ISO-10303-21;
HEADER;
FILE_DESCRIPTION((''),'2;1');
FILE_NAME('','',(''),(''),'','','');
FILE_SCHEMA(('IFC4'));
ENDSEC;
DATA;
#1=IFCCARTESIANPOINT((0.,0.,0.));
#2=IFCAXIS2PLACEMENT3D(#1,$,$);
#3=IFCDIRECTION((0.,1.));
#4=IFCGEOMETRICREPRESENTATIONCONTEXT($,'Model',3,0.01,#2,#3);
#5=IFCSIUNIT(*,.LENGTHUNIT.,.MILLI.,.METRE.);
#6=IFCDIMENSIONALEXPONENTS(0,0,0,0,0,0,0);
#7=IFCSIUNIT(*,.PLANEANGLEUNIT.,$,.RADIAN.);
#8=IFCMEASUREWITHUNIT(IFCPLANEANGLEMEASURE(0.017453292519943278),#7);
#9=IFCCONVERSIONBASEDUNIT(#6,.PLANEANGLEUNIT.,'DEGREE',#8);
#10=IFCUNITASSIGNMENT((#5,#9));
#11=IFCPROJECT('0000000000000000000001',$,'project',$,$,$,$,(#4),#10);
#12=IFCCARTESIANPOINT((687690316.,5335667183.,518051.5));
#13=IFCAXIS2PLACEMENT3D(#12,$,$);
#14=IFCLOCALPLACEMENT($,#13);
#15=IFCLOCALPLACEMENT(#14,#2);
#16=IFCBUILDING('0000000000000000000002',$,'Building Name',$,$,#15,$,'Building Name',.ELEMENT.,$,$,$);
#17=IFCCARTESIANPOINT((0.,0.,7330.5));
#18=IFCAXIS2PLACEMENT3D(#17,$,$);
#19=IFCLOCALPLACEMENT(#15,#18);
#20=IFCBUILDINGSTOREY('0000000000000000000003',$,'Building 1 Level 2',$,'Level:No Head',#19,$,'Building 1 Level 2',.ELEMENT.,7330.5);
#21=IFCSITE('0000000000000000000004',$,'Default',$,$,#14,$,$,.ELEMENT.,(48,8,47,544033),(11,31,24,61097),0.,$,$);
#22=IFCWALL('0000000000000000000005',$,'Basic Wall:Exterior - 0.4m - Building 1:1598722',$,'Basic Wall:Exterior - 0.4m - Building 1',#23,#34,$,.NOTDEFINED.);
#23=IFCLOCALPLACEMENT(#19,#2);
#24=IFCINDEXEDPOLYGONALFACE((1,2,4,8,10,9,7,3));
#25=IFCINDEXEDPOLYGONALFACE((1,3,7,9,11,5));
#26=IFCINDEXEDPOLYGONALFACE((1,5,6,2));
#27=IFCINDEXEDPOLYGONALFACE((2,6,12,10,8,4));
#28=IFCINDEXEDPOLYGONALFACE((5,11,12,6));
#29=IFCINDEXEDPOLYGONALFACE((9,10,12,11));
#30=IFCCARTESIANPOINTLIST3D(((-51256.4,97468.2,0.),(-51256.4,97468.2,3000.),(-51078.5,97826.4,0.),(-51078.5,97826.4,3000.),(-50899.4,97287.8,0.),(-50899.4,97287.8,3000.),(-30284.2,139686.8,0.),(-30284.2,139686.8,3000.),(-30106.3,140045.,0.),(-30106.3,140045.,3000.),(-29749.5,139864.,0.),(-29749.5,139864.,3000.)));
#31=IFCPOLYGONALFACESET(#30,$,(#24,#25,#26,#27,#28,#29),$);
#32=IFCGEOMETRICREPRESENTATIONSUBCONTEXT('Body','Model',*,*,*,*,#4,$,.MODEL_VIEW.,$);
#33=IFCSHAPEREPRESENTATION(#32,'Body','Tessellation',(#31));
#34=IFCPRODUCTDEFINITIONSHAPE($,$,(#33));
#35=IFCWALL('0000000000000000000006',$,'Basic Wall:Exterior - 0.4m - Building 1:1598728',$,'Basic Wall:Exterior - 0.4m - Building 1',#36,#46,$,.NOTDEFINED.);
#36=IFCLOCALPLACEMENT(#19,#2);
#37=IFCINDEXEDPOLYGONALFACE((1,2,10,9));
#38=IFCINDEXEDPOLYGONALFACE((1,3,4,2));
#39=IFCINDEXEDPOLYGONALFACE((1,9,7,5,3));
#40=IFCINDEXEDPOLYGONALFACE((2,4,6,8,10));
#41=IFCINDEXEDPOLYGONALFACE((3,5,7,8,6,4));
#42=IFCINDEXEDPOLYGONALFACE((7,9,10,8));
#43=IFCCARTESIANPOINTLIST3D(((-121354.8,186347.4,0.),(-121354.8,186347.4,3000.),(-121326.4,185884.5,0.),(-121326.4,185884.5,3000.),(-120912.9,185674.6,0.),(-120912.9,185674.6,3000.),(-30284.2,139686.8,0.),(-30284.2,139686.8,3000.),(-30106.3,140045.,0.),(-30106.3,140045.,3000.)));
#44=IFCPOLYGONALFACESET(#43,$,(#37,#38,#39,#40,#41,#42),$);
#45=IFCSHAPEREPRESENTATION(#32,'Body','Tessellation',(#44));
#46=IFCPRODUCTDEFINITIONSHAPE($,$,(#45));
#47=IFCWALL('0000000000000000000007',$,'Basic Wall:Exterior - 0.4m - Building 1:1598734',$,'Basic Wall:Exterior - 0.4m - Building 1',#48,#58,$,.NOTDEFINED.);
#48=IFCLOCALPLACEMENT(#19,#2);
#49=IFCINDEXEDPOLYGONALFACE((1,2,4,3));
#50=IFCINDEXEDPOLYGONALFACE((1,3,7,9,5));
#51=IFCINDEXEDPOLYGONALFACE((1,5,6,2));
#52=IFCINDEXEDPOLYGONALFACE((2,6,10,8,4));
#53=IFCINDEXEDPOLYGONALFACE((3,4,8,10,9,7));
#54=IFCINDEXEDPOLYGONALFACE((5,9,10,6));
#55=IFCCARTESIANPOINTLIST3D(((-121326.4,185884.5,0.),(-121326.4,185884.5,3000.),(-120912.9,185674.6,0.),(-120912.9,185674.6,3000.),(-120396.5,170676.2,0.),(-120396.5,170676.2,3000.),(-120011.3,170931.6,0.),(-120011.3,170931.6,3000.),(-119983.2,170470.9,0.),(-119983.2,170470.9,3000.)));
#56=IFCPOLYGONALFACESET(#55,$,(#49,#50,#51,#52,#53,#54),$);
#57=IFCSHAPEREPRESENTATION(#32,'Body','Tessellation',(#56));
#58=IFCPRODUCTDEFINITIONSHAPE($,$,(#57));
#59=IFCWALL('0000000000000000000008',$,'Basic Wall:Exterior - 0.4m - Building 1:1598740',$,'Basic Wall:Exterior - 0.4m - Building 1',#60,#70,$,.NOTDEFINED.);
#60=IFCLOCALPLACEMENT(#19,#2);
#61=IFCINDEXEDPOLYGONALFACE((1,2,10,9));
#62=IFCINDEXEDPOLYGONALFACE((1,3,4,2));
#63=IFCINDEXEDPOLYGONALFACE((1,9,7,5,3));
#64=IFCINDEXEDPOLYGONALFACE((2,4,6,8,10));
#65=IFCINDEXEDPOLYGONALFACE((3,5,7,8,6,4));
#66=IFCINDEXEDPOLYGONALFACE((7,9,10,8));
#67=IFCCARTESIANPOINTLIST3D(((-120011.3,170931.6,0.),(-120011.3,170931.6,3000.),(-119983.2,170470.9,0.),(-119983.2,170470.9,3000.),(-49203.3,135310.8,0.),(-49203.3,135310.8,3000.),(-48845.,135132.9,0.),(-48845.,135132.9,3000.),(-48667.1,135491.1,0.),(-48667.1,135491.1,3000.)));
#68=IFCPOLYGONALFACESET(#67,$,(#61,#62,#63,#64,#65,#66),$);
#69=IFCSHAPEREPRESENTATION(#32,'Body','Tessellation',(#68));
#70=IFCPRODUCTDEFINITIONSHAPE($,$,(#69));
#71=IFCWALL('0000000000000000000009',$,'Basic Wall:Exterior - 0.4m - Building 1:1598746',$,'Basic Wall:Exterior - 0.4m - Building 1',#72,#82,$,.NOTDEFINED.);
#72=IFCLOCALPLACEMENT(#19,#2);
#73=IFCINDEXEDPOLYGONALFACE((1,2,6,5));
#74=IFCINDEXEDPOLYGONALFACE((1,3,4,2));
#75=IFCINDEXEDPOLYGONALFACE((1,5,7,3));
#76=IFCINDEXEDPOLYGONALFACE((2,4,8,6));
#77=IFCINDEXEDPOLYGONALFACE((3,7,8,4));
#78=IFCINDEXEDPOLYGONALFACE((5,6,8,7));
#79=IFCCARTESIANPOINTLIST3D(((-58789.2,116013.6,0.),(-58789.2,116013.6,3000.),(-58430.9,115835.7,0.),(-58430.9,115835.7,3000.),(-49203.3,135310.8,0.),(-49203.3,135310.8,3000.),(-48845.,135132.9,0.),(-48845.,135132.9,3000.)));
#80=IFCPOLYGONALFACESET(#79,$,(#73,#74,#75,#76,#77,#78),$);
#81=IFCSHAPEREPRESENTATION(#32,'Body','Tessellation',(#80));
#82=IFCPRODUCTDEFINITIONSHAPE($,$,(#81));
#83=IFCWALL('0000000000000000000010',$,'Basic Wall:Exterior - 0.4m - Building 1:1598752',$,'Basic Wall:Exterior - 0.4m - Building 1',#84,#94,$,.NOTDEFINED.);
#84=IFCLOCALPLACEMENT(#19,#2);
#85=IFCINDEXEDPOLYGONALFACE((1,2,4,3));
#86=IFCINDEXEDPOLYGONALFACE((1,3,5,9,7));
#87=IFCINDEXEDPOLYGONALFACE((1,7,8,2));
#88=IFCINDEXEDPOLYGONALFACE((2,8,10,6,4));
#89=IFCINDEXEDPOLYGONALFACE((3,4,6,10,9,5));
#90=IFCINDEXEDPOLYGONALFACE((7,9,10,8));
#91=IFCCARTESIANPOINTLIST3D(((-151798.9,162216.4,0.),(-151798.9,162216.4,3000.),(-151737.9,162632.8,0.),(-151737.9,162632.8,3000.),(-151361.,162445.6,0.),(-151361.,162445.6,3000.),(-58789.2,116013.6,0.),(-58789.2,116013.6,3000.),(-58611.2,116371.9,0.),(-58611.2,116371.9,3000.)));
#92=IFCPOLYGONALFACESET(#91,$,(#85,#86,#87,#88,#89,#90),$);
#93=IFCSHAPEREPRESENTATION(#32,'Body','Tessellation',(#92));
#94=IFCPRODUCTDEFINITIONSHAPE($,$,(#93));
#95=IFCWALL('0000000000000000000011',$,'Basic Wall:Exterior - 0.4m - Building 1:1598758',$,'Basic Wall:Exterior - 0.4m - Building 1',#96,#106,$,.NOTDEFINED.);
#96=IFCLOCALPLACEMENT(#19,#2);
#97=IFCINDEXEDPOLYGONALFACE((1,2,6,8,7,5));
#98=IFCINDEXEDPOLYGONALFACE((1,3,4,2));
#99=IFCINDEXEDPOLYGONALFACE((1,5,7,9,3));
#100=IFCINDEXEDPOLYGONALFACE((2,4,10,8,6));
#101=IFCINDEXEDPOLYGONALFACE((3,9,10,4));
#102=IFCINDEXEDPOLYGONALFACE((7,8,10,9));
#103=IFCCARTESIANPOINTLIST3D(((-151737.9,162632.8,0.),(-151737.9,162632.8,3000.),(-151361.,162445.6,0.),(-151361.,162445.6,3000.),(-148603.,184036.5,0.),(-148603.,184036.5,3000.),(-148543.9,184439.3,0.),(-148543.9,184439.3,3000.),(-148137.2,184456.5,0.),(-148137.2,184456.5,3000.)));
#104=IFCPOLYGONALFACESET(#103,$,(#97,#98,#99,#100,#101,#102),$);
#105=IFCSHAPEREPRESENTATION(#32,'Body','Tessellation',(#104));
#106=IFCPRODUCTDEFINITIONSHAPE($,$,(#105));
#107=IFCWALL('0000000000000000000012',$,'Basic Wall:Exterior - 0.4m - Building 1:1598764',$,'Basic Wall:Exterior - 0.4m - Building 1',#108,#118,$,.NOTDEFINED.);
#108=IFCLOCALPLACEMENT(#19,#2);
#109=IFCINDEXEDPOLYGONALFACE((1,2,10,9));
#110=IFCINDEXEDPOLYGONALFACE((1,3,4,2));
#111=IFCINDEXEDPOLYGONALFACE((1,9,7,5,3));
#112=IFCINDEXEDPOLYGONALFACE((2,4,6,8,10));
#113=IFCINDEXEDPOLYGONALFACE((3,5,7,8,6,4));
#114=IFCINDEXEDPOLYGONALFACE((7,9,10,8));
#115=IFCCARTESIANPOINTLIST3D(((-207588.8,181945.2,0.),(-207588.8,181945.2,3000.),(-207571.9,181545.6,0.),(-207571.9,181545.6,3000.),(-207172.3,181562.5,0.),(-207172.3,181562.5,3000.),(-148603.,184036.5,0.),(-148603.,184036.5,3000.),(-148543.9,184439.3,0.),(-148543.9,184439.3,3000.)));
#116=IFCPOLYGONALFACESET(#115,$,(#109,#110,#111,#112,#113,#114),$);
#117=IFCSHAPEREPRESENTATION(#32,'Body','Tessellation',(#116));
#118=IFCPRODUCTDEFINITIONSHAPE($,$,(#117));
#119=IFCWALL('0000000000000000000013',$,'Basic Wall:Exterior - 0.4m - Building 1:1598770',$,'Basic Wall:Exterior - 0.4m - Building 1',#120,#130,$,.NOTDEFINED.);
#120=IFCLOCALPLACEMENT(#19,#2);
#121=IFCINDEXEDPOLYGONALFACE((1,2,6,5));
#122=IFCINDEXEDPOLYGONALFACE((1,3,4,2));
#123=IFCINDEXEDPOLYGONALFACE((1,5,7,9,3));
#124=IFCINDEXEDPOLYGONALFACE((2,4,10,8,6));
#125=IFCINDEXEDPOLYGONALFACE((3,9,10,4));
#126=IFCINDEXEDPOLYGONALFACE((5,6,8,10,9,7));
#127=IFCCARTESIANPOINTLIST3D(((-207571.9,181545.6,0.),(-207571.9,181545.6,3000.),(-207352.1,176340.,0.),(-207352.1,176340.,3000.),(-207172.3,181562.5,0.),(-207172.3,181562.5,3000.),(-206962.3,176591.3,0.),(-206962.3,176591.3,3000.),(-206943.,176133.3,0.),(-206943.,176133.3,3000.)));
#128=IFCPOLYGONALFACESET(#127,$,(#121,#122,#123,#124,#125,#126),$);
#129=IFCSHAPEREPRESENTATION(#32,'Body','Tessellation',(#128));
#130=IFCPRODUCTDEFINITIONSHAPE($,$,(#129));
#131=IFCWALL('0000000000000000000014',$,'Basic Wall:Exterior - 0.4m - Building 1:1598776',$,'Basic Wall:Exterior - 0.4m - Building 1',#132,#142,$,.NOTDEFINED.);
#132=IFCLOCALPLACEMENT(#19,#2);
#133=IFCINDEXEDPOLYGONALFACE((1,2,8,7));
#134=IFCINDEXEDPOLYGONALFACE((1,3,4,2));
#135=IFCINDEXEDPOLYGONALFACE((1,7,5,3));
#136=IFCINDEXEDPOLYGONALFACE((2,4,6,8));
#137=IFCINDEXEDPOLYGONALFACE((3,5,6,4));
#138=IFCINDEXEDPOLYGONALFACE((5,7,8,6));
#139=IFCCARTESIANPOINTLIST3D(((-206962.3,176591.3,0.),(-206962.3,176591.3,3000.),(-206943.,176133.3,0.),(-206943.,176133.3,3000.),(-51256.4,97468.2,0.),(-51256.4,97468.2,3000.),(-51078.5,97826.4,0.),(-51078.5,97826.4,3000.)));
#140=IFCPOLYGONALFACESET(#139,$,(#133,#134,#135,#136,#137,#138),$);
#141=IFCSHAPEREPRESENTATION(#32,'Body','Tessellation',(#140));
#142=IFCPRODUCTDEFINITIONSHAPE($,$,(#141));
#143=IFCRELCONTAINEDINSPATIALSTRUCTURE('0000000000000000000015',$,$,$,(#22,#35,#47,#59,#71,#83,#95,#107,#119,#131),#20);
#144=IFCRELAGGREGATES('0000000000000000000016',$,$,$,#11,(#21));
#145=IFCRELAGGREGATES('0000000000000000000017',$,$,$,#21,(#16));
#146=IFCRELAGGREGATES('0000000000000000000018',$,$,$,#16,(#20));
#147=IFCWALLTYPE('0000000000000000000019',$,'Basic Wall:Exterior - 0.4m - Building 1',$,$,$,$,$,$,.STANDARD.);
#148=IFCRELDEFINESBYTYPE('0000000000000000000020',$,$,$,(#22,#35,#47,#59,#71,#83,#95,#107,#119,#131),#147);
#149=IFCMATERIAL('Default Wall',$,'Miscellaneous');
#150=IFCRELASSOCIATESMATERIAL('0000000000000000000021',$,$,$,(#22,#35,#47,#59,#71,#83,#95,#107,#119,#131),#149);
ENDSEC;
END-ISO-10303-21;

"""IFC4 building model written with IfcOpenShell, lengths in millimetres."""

from ifc_helpers import new_model, entity, si_unit, converted_unit, direction, frame, origin, place, context, subcontext, project, spatial, indexed_curve, outline, extrude, material, type_object, element, save


model = new_model("IFC4")

# Units and contexts
model_context = context("Model", 3, precision=0.01, world=origin(), true_north=direction((0.0, 1.0)))
body_context = subcontext(model_context, "Body", "Model", "MODEL_VIEW")
ifc_project = project(units=[si_unit("LENGTHUNIT", "METRE", prefix="MILLI"), converted_unit("PLANEANGLEUNIT", "DEGREE", entity("IfcPlaneAngleMeasure", 0.017453292519943278), si_unit("PLANEANGLEUNIT", "RADIAN"), dimensions=[0, 0, 0, 0, 0, 0, 0])], contexts=[model_context])

# Site, building, storey
site_placement = place(None, frame((687690316.0, 5335667183.0, 518051.5)))
site = spatial("IfcSite", under=ifc_project, at=site_placement, Name="Default", CompositionType="ELEMENT", RefLatitude=(48, 8, 47, 544033), RefLongitude=(11, 31, 24, 61097), RefElevation=0.0)
building_placement = place(site_placement, origin())
building = spatial("IfcBuilding", under=site, at=building_placement, Name="Building Name", LongName="Building Name", CompositionType="ELEMENT")
storey_placement = place(building_placement, frame((0.0, 0.0, 7330.5)))
storey = spatial("IfcBuildingStorey", under=building, at=storey_placement, Name="Building 1 Level 2", ObjectType="Level:No Head", LongName="Building 1 Level 2", CompositionType="ELEMENT", Elevation=7330.5)

# Walls
ifc_material_1 = material(Name="Default Wall", Category="Miscellaneous")
wall_type = type_object("IfcWallType", Name="Basic Wall:Exterior - 0.4m - Building 1", PredefinedType="STANDARD")
wall_1_placement = place(storey_placement, frame((-51078.5, 97376.7, 0.0), z_axis=(0.0, 0.0, 1.0), x_axis=(0.444885, 0.895588, 0.0)))
element("IfcWall", 1, at=wall_1_placement, inside=storey, type_object=wall_type, material=ifc_material_1, Name="Basic Wall:Exterior - 0.4m - Building 1:1598722", ObjectType="Basic Wall:Exterior - 0.4m - Building 1", PredefinedType="NOTDEFINED", context=body_context, shape_type="SweptSolid", body=[
    extrude(outline(indexed_curve([(47540.0, -200.0), (47543.5, 200.0), (47143.4, 200.0), (402.7, 200.0), (2.7, 200.0), (0.0, -200.0), (47540.0, -200.0)], self_intersect=False)), origin(), (0.0, 0.0, 1.0), 3000.0),
])
wall_2_placement = place(storey_placement, frame((-30193.7, 139865.1, 0.0), z_axis=(0.0, 0.0, 1.0), x_axis=(-0.891761, 0.452507, 0.0)))
element("IfcWall", 2, at=wall_2_placement, inside=storey, type_object=wall_type, material=ifc_material_1, Name="Basic Wall:Exterior - 0.4m - Building 1:1598728", ObjectType="Basic Wall:Exterior - 0.4m - Building 1", PredefinedType="NOTDEFINED", context=body_context, shape_type="SweptSolid", body=[
    extrude(outline(indexed_curve([(102327.4, -200.0), (102092.7, 200.0), (101628.9, 200.0), (0.0, 200.0), (3.4, -200.0), (102327.4, -200.0)], self_intersect=False)), origin(), (0.0, 0.0, 1.0), 3000.0),
])
wall_3_placement = place(storey_placement, frame((-121126.8, 185896.7, 0.0), z_axis=(0.0, 0.0, 1.0), x_axis=(0.061037, -0.998136, 0.0)))
element("IfcWall", 3, at=wall_3_placement, inside=storey, type_object=wall_type, material=ifc_material_1, Name="Basic Wall:Exterior - 0.4m - Building 1:1598734", ObjectType="Basic Wall:Exterior - 0.4m - Building 1", PredefinedType="NOTDEFINED", context=body_context, shape_type="SweptSolid", body=[
    extrude(outline(indexed_curve([(15236.7, -200.0), (15466.8, 200.0), (15005.3, 200.0), (234.7, 200.0), (0.0, -200.0), (15236.7, -200.0)], self_intersect=False)), origin(), (0.0, 0.0, 1.0), 3000.0),
])
wall_4_placement = place(storey_placement, frame((-120100.3, 170752.4, 0.0), z_axis=(0.0, 0.0, 1.0), x_axis=(0.895588, -0.444885, 0.0)))
element("IfcWall", 4, at=wall_4_placement, inside=storey, type_object=wall_type, material=ifc_material_1, Name="Basic Wall:Exterior - 0.4m - Building 1:1598740", ObjectType="Basic Wall:Exterior - 0.4m - Building 1", PredefinedType="NOTDEFINED", context=body_context, shape_type="SweptSolid", body=[
    extrude(outline(indexed_curve([(79662.0, -200.0), (79662.0, 200.0), (0.0, 200.0), (230.2, -200.0), (79262.0, -200.0), (79662.0, -200.0)], self_intersect=False)), origin(), (0.0, 0.0, 1.0), 3000.0),
])
wall_5_placement = place(storey_placement, frame((-49024.1, 135221.9, 0.0), z_axis=(0.0, 0.0, 1.0), x_axis=(-0.444885, -0.895588, 0.0)))
element("IfcWall", 5, at=wall_5_placement, inside=storey, type_object=wall_type, material=ifc_material_1, Name="Basic Wall:Exterior - 0.4m - Building 1:1598746", ObjectType="Basic Wall:Exterior - 0.4m - Building 1", PredefinedType="NOTDEFINED", context=body_context, shape_type="SweptSolid", body=[
    extrude(outline(indexed_curve([(21547.0, 200.0), (0.0, 200.0), (0.0, -200.0), (21547.0, -200.0), (21547.0, 200.0)], self_intersect=False)), origin(), (0.0, 0.0, 1.0), 3000.0),
])
wall_6_placement = place(storey_placement, frame((-58700.2, 116192.8, 0.0), z_axis=(0.0, 0.0, 1.0), x_axis=(-0.895588, 0.444885, 0.0)))
element("IfcWall", 6, at=wall_6_placement, inside=storey, type_object=wall_type, material=ifc_material_1, Name="Basic Wall:Exterior - 0.4m - Building 1:1598752", ObjectType="Basic Wall:Exterior - 0.4m - Building 1", PredefinedType="NOTDEFINED", context=body_context, shape_type="SweptSolid", body=[
    extrude(outline(indexed_curve([(103983.9, -200.0), (103853.3, 200.0), (0.0, 200.0), (0.0, -200.0), (103563.1, -200.0), (103983.9, -200.0)], self_intersect=False)), origin(), (0.0, 0.0, 1.0), 3000.0),
])
wall_7_placement = place(storey_placement, frame((-151558.9, 162474.6, 0.0), z_axis=(0.0, 0.0, 1.0), x_axis=(0.144921, 0.989443, 0.0)))
element("IfcWall", 7, at=wall_7_placement, inside=storey, type_object=wall_type, material=ifc_material_1, Name="Basic Wall:Exterior - 0.4m - Building 1:1598758", ObjectType="Basic Wall:Exterior - 0.4m - Building 1", PredefinedType="NOTDEFINED", context=body_context, shape_type="SweptSolid", body=[
    extrude(outline(indexed_curve([(22245.8, -200.0), (22169.8, 200.0), (21762.7, 200.0), (130.6, 200.0), (0.0, -200.0), (22245.8, -200.0)], self_intersect=False)), origin(), (0.0, 0.0, 1.0), 3000.0),
])
wall_8_placement = place(storey_placement, frame((-148535.5, 184239.5, 0.0), z_axis=(0.0, 0.0, 1.0), x_axis=(-0.999109, -0.042203, 0.0)))
element("IfcWall", 8, at=wall_8_placement, inside=storey, type_object=wall_type, material=ifc_material_1, Name="Basic Wall:Exterior - 0.4m - Building 1:1598764", ObjectType="Basic Wall:Exterior - 0.4m - Building 1", PredefinedType="NOTDEFINED", context=body_context, shape_type="SweptSolid", body=[
    extrude(outline(indexed_curve([(59097.5, -200.0), (59097.5, 200.0), (58697.5, 200.0), (76.0, 200.0), (0.0, -200.0), (59097.5, -200.0)], self_intersect=False)), origin(), (0.0, 0.0, 1.0), 3000.0),
])
wall_9_placement = place(storey_placement, frame((-207372.1, 181554.0, 0.0), z_axis=(0.0, 0.0, 1.0), x_axis=(0.042203, -0.999109, 0.0)))
element("IfcWall", 9, at=wall_9_placement, inside=storey, type_object=wall_type, material=ifc_material_1, Name="Basic Wall:Exterior - 0.4m - Building 1:1598770", ObjectType="Basic Wall:Exterior - 0.4m - Building 1", PredefinedType="NOTDEFINED", context=body_context, shape_type="SweptSolid", body=[
    extrude(outline(indexed_curve([(5210.2, -200.0), (5434.0, 200.0), (4975.6, 200.0), (0.0, 200.0), (0.0, -200.0), (5210.2, -200.0)], self_intersect=False)), origin(), (0.0, 0.0, 1.0), 3000.0),
])
wall_10_placement = place(storey_placement, frame((-207052.5, 176412.8, 0.0), z_axis=(0.0, 0.0, 1.0), x_axis=(0.892534, -0.450979, 0.0)))
element("IfcWall", 10, at=wall_10_placement, inside=storey, type_object=wall_type, material=ifc_material_1, Name="Basic Wall:Exterior - 0.4m - Building 1:1598776", ObjectType="Basic Wall:Exterior - 0.4m - Building 1", PredefinedType="NOTDEFINED", context=body_context, shape_type="SweptSolid", body=[
    extrude(outline(indexed_curve([(174655.7, -200.0), (174653.0, 200.0), (0.0, 200.0), (223.8, -200.0), (174655.7, -200.0)], self_intersect=False)), origin(), (0.0, 0.0, 1.0), 3000.0),
])

save(model, "model.ifc")
